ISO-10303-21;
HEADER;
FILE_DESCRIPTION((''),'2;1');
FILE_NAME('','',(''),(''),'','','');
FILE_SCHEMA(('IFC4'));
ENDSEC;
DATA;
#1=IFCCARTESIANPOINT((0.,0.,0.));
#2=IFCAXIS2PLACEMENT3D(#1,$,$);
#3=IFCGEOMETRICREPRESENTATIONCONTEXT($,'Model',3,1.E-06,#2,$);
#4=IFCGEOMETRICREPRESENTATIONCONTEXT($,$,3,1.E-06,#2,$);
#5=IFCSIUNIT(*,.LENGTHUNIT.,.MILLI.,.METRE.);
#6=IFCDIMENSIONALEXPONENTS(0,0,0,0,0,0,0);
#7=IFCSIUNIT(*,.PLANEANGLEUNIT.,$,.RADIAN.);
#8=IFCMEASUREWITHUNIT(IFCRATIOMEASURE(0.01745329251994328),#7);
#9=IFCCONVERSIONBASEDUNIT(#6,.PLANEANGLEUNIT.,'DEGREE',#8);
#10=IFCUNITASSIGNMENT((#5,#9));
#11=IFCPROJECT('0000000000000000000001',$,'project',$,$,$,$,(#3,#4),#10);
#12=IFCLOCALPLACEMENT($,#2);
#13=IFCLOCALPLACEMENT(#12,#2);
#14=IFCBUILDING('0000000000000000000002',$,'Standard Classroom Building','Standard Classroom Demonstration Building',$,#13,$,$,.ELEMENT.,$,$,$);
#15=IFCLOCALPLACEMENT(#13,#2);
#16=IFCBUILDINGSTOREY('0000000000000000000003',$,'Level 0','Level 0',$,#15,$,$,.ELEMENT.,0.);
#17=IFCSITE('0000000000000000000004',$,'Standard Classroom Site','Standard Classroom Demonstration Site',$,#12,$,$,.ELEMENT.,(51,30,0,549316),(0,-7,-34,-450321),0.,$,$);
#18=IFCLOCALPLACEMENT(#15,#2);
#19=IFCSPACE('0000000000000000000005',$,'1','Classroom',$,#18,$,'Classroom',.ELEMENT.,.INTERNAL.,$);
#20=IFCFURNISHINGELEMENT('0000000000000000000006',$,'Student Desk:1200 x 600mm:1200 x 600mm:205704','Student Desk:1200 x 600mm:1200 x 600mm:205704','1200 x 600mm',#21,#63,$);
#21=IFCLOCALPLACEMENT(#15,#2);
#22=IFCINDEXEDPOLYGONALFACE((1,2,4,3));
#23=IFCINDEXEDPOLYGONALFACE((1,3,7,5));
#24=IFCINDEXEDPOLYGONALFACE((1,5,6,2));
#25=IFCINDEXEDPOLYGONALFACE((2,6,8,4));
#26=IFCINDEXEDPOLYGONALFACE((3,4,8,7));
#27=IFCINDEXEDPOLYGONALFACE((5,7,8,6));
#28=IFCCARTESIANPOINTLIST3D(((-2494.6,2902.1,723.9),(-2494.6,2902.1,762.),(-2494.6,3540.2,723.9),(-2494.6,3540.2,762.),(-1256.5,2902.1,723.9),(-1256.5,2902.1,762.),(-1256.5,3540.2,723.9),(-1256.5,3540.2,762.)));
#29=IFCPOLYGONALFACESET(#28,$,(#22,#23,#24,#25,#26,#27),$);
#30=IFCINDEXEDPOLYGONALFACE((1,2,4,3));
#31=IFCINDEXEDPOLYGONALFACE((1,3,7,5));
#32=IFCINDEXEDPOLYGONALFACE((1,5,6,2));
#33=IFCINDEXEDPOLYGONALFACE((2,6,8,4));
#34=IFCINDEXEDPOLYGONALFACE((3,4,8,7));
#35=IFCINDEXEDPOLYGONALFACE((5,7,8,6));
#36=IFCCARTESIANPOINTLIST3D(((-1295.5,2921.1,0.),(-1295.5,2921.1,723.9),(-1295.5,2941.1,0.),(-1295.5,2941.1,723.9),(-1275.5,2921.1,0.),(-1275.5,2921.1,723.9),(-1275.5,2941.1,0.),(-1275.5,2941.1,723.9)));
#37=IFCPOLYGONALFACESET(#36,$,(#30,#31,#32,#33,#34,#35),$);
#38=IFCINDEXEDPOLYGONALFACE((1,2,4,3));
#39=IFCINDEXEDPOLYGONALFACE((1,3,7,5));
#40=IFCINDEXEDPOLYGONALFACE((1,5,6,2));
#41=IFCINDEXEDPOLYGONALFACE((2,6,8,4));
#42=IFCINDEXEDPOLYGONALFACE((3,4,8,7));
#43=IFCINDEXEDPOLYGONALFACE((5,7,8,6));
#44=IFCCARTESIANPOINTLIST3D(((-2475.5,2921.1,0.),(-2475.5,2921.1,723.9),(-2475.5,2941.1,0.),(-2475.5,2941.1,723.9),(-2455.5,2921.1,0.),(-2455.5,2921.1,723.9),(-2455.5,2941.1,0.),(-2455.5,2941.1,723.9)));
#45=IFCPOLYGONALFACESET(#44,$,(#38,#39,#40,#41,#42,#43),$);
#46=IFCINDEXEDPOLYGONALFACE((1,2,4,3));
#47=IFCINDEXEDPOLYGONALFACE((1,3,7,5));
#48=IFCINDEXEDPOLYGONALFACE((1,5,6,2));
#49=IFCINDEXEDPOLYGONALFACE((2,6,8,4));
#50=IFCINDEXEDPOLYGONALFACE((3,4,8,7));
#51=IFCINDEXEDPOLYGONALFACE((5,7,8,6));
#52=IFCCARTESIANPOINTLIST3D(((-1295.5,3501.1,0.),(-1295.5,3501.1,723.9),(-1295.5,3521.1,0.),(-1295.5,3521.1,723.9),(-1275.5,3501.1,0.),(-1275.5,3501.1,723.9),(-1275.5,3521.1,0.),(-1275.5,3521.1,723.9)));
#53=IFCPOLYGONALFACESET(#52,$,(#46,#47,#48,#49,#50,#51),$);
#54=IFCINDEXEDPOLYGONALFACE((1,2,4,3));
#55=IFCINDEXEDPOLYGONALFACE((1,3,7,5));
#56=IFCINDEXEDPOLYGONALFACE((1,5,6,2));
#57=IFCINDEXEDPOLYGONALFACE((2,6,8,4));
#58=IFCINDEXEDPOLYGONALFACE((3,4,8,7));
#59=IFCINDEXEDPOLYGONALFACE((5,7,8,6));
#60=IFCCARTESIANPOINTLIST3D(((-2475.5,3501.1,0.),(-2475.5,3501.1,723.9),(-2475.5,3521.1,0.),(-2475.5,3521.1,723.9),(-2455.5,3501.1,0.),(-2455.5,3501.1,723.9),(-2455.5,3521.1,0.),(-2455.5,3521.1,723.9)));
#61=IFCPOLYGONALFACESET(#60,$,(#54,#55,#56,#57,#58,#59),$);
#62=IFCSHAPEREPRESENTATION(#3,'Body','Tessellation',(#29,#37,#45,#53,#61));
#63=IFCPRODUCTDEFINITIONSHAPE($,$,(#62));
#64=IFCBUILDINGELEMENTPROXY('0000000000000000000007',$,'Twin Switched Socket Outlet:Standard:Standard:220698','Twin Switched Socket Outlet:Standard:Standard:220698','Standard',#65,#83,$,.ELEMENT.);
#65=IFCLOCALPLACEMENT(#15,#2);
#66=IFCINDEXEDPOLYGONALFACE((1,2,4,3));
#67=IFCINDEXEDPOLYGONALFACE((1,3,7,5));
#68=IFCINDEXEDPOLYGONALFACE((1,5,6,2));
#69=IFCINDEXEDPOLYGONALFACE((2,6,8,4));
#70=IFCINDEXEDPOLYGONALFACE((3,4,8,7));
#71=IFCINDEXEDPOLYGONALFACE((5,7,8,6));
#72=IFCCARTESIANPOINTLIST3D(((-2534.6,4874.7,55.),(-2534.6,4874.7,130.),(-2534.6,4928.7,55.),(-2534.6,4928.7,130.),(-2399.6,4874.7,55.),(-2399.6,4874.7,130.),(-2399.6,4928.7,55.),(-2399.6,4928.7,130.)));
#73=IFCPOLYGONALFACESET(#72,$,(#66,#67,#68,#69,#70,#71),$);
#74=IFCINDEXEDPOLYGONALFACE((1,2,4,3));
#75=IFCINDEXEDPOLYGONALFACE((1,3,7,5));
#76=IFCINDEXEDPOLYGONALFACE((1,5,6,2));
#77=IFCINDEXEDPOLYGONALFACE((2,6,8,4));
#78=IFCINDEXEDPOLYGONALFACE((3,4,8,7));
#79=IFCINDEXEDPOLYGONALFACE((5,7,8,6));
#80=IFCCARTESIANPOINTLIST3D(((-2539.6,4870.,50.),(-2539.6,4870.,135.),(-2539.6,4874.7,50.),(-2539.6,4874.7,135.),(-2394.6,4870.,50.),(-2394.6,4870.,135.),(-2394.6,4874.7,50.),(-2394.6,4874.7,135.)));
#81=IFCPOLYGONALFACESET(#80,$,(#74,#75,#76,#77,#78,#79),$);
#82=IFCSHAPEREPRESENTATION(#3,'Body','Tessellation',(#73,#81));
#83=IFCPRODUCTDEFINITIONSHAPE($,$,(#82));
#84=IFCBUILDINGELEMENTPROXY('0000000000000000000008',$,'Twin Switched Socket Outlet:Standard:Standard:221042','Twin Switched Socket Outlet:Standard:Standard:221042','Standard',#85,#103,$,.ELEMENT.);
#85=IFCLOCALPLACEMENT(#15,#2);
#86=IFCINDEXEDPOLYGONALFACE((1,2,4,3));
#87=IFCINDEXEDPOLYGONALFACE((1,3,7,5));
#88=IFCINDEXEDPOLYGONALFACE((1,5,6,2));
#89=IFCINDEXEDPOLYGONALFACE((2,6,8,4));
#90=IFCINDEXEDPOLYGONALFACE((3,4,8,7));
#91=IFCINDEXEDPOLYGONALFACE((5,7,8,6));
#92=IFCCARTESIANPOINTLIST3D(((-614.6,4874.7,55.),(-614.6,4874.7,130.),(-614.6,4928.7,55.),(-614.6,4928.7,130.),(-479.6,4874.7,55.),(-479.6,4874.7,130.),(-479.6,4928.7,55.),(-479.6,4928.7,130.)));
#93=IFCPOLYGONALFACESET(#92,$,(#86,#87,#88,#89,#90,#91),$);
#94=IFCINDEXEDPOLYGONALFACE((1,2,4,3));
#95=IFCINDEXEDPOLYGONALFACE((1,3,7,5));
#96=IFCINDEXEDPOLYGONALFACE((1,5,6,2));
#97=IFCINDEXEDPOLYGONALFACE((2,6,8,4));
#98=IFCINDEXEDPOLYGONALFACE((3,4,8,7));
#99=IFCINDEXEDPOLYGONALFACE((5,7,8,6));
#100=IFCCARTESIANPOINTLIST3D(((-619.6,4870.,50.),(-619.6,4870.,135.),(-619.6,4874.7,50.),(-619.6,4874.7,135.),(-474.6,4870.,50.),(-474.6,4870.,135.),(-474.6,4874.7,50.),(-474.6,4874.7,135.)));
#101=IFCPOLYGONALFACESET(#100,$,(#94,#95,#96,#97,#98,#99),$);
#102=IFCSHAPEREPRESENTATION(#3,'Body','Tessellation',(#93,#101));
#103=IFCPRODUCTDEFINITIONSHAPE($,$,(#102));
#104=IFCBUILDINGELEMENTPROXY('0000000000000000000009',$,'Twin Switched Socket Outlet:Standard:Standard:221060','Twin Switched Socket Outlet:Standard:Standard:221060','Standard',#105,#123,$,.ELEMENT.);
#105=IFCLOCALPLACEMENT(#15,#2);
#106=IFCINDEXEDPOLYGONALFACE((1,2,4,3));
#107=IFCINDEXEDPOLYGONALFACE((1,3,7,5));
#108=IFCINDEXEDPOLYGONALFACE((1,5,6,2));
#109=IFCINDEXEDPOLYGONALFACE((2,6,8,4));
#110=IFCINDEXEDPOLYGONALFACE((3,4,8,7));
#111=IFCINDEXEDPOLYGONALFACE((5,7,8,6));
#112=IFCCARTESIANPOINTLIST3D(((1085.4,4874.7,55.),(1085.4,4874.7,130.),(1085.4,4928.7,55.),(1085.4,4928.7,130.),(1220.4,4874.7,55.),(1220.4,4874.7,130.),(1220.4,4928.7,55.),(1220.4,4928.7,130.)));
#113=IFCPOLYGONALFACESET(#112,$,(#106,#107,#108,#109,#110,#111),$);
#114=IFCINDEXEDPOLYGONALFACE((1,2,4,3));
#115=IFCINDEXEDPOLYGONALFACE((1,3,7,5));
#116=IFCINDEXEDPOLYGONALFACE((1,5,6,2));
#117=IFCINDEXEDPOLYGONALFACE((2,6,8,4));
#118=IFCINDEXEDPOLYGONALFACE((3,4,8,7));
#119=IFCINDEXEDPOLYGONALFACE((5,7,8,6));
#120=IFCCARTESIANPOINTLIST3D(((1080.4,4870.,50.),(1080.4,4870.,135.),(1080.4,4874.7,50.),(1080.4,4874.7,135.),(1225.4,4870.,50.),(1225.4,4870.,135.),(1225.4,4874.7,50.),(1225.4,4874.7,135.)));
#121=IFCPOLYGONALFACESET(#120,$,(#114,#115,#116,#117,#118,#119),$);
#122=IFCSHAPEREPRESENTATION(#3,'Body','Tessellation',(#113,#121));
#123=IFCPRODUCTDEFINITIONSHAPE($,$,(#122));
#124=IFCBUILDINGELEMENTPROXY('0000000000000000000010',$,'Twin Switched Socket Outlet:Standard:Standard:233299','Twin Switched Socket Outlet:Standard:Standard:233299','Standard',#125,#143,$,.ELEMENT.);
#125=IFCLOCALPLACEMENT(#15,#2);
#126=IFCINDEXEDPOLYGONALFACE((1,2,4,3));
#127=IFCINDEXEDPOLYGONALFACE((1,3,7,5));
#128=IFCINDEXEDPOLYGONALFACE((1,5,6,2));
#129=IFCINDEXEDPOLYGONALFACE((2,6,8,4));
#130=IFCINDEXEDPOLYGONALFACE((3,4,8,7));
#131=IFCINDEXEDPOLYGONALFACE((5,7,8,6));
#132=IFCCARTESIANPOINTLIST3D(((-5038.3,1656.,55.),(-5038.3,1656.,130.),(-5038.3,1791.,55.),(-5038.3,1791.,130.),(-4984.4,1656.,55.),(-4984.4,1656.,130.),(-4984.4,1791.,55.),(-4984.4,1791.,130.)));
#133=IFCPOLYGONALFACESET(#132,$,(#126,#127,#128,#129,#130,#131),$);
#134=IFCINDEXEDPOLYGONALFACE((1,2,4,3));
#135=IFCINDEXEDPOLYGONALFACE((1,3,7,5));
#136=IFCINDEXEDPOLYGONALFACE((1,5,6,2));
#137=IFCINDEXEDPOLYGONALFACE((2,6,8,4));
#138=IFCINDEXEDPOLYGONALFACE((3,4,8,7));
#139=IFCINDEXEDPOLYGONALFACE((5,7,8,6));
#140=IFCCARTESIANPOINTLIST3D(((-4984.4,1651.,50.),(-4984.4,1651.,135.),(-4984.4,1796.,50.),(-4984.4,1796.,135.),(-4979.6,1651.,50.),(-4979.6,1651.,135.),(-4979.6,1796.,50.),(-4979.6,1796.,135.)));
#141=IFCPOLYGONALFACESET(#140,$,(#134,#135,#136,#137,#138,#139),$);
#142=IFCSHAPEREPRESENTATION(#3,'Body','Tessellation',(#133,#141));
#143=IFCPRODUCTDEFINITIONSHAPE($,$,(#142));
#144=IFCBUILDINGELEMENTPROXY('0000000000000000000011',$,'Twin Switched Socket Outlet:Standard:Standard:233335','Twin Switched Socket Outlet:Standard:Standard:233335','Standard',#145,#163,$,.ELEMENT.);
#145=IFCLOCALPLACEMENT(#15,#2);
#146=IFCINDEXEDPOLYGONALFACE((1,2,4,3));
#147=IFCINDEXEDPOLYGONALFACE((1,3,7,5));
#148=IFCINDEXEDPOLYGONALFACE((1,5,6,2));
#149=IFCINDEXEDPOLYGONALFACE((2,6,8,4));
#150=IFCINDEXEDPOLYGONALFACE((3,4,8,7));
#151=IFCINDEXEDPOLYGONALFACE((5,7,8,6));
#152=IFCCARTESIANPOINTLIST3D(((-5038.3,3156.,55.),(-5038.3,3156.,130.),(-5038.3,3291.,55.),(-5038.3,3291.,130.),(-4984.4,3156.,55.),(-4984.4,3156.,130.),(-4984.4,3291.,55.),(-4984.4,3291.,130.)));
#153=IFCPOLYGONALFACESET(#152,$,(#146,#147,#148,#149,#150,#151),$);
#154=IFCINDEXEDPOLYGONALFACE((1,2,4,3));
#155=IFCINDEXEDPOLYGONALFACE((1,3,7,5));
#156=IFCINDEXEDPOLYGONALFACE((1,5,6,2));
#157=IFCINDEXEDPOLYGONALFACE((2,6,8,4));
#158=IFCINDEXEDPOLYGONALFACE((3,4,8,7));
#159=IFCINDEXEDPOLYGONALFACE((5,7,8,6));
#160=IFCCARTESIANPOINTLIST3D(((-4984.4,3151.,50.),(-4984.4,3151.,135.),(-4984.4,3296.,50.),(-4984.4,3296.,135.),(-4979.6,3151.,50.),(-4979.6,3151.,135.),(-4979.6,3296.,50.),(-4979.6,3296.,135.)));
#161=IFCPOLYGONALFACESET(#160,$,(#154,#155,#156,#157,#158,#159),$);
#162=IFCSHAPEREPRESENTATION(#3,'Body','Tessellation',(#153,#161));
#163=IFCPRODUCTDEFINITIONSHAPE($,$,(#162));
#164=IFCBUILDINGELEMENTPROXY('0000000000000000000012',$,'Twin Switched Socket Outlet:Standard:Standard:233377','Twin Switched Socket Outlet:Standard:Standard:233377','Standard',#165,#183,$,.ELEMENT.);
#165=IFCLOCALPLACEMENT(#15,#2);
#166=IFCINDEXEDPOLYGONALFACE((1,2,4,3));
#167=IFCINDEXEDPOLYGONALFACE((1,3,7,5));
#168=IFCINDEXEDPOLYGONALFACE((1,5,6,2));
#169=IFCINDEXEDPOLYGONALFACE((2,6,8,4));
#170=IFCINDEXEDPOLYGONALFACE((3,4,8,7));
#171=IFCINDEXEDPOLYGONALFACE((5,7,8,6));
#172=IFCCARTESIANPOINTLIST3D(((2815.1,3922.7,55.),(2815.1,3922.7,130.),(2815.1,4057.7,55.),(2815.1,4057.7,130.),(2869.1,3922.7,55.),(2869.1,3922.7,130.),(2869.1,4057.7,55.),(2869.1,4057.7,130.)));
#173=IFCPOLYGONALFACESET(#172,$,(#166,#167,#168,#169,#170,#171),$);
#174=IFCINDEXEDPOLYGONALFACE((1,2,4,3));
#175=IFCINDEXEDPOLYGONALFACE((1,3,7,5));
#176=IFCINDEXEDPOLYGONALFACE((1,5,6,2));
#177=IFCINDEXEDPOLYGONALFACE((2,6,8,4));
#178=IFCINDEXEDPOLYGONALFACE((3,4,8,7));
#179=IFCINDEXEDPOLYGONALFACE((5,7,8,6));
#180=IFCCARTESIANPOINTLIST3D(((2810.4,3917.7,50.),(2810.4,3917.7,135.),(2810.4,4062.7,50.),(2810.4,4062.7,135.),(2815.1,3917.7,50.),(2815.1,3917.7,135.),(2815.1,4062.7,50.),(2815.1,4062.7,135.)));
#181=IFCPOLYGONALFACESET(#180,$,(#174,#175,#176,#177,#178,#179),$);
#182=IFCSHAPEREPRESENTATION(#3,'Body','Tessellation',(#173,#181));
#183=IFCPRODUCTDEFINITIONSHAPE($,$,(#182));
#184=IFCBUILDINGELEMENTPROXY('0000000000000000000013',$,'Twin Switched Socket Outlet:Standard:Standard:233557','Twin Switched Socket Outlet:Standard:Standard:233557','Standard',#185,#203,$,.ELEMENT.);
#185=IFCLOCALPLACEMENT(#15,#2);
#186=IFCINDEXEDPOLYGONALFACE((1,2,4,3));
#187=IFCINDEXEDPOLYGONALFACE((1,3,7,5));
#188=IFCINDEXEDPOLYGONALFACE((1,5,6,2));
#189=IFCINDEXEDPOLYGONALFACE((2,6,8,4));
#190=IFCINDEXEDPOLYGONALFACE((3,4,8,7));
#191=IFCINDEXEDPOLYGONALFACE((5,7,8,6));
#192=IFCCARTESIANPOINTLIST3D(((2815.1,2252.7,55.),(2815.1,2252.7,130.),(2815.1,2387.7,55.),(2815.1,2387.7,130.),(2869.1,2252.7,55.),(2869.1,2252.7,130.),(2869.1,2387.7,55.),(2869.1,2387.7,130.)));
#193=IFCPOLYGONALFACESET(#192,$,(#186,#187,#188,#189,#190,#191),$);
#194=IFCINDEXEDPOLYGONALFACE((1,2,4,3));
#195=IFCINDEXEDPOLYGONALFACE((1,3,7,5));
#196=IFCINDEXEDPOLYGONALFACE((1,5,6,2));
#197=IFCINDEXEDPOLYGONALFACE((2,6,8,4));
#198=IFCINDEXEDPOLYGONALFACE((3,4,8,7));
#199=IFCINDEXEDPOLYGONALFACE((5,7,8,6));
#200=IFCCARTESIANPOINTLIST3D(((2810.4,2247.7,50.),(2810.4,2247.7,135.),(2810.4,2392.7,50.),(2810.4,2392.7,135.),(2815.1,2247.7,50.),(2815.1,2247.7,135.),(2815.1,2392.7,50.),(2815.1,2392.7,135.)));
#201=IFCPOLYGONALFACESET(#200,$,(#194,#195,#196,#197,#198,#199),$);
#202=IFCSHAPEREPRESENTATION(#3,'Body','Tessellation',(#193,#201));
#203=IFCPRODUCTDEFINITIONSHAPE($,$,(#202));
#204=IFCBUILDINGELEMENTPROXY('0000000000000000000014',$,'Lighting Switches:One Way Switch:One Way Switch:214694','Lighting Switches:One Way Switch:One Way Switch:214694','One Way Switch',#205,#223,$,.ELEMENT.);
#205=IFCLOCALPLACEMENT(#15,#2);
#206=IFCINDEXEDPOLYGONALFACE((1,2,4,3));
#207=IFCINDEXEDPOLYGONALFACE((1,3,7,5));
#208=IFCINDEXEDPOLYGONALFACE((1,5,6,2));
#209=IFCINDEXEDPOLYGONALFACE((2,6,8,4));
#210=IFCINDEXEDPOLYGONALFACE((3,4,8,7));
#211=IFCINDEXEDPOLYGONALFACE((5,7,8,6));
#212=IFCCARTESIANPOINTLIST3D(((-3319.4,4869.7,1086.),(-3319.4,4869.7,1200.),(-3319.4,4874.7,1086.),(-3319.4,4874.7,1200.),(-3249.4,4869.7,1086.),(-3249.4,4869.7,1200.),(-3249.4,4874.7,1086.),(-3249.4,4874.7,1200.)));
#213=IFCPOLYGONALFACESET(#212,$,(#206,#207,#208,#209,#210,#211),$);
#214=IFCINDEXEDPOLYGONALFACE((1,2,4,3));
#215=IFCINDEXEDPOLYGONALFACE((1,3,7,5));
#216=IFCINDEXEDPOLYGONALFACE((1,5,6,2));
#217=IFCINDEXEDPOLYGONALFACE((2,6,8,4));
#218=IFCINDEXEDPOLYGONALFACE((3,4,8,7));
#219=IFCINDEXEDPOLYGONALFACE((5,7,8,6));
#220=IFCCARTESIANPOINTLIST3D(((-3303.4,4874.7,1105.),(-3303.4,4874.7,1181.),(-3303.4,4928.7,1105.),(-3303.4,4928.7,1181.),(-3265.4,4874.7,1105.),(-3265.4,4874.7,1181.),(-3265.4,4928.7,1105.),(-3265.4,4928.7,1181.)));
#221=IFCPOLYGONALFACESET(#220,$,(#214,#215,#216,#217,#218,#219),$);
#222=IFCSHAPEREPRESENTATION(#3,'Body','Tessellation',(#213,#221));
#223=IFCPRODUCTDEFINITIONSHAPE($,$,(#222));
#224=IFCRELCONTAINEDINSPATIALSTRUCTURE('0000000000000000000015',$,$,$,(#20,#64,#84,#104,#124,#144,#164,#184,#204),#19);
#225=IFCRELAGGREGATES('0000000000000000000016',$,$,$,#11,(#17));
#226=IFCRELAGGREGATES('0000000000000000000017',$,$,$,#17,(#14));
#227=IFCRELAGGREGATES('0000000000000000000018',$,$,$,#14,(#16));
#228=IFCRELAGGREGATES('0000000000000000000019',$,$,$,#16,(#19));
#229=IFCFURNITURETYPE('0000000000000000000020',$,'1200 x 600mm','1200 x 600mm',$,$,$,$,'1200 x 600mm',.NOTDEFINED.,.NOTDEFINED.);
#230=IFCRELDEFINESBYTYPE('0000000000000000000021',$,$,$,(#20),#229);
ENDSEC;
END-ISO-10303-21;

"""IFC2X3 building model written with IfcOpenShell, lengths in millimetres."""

from ifc_helpers import new_model, entity, si_unit, converted_unit, frame, origin, origin_2d_with_axis, place, context, project, spatial, rectangle, extrude, source, transform, mapped, type_object, type_shapes, element, save


model = new_model("IFC2X3")

# Units and contexts
model_context = context("Model", 3, precision=1e-06, world=origin())
context_of_model = context(None, 3, precision=1e-06, world=origin())
ifc_project = project(units=[si_unit("LENGTHUNIT", "METRE", prefix="MILLI"), converted_unit("PLANEANGLEUNIT", "DEGREE", entity("IfcRatioMeasure", 0.01745329251994328), si_unit("PLANEANGLEUNIT", "RADIAN"), dimensions=[0, 0, 0, 0, 0, 0, 0])], contexts=[model_context, context_of_model])

# Site, building, storey
site_placement = place(None, origin())
site = spatial("IfcSite", under=ifc_project, at=site_placement, Name="Standard Classroom Site", Description="Standard Classroom Demonstration Site", CompositionType="ELEMENT", RefLatitude=(51, 30, 0, 549316), RefLongitude=(0, -7, -34, -450321), RefElevation=0.0)
building_placement = place(site_placement, origin())
building = spatial("IfcBuilding", under=site, at=building_placement, Name="Standard Classroom Building", Description="Standard Classroom Demonstration Building", CompositionType="ELEMENT")
storey_placement = place(building_placement, origin())
storey = spatial("IfcBuildingStorey", under=building, at=storey_placement, Name="Level 0", Description="Level 0", CompositionType="ELEMENT", Elevation=0.0)

# Shared definitions
space_placement = place(storey_placement, origin())
space = spatial("IfcSpace", under=storey, at=space_placement, Name="1", Description="Classroom", LongName="Classroom", CompositionType="ELEMENT", InteriorOrExteriorSpace="INTERNAL")

# Furnishing element
furniture_type = type_object("IfcFurnitureType", Name="1200 x 600mm", Description="1200 x 600mm", ElementType="1200 x 600mm", AssemblyPlace="NOTDEFINED")
shared_shape_1 = source(origin(), model_context, "Body", "SweptSolid", [
    extrude(rectangle(XDim=1238.1, YDim=638.1, at=origin_2d_with_axis()), frame((600.0, 300.0, 723.9), z_axis=(0.0, 0.0, 1.0), x_axis=(-1.0, 0.0, 0.0)), (0.0, 0.0, 1.0), 38.1),
    extrude(rectangle(XDim=20.0, YDim=20.0, at=origin_2d_with_axis()), frame((1190.0, 10.0, 0.0)), (0.0, 0.0, 1.0), 723.9),
    extrude(rectangle(XDim=20.0, YDim=20.0, at=origin_2d_with_axis()), frame((10.0, 10.0, 0.0), z_axis=(0.0, 0.0, 1.0), x_axis=(0.0, 1.0, 0.0)), (0.0, 0.0, 1.0), 723.9),
    extrude(rectangle(XDim=20.0, YDim=20.0, at=origin_2d_with_axis()), frame((1190.0, 590.0, 0.0), z_axis=(0.0, 0.0, 1.0), x_axis=(0.0, -1.0, 0.0)), (0.0, 0.0, 1.0), 723.9),
    extrude(rectangle(XDim=20.0, YDim=20.0, at=origin_2d_with_axis()), frame((10.0, 590.0, 0.0), z_axis=(0.0, 0.0, 1.0), x_axis=(-1.0, 0.0, 0.0)), (0.0, 0.0, 1.0), 723.9),
])
type_shapes(furniture_type, [shared_shape_1])
for number, where, name in (
    (1, (-2475.5, 2921.1, 0.0), "Student Desk:1200 x 600mm:1200 x 600mm:205704"),
):
    element("IfcFurnishingElement", number, at=place(space_placement, frame(where)), inside=space, type_object=furniture_type, Name=name, Description="Student Desk:1200 x 600mm:1200 x 600mm:205704", ObjectType="1200 x 600mm", context=model_context, shape_type="MappedRepresentation", body=[
        mapped(shared_shape_1, transform((0.0, 0.0, 0.0), scale=1.0)),
    ])

# Building element proxies
shared_shape_2 = source(origin(), model_context, "Body", "SweptSolid", [
    extrude(rectangle(XDim=135.0, YDim=75.0, at=origin_2d_with_axis()), frame((0.0, 0.0, -54.0), z_axis=(0.0, 0.0, 1.0), x_axis=(-1.0, 0.0, 0.0)), (0.0, 0.0, 1.0), 54.0),
    extrude(rectangle(XDim=145.0, YDim=85.0, at=origin_2d_with_axis()), frame((0.0, 0.0, 0.0), z_axis=(0.0, 0.0, 1.0), x_axis=(-1.0, 0.0, 0.0)), (0.0, 0.0, 1.0), 4.8),
])
for number, where, z_axis, x_axis, name, description in (
    (2, (-2467.1, 4874.7, 92.5), (0.0, -1.0, 0.0), (1.0, 0.0, 0.0), "Twin Switched Socket Outlet:Standard:Standard:220698", "Twin Switched Socket Outlet:Standard:Standard:220698"),
    (3, (-547.1, 4874.7, 92.5), (0.0, -1.0, 0.0), (1.0, 0.0, 0.0), "Twin Switched Socket Outlet:Standard:Standard:221042", "Twin Switched Socket Outlet:Standard:Standard:221042"),
    (4, (1152.9, 4874.7, 92.5), (0.0, -1.0, 0.0), (1.0, 0.0, 0.0), "Twin Switched Socket Outlet:Standard:Standard:221060", "Twin Switched Socket Outlet:Standard:Standard:221060"),
    (5, (-4984.4, 1723.5, 92.5), (1.0, 0.0, 0.0), (0.0, 1.0, 0.0), "Twin Switched Socket Outlet:Standard:Standard:233299", "Twin Switched Socket Outlet:Standard:Standard:233299"),
    (6, (-4984.4, 3223.5, 92.5), (1.0, 0.0, 0.0), (0.0, 1.0, 0.0), "Twin Switched Socket Outlet:Standard:Standard:233335", "Twin Switched Socket Outlet:Standard:Standard:233335"),
    (7, (2815.1, 3990.2, 92.5), (-1.0, 0.0, 0.0), (0.0, -1.0, 0.0), "Twin Switched Socket Outlet:Standard:Standard:233377", "Twin Switched Socket Outlet:Standard:Standard:233377"),
    (8, (2815.1, 2320.2, 92.5), (-1.0, 0.0, 0.0), (0.0, -1.0, 0.0), "Twin Switched Socket Outlet:Standard:Standard:233557", "Twin Switched Socket Outlet:Standard:Standard:233557"),
):
    element("IfcBuildingElementProxy", number, at=place(space_placement, frame(where, z_axis=z_axis, x_axis=x_axis)), inside=space, Name=name, Description=description, ObjectType="Standard", CompositionType="ELEMENT", context=model_context, shape_type="MappedRepresentation", body=[
        mapped(shared_shape_2, transform((0.0, 0.0, 0.0), scale=1.0)),
    ])
shared_shape_3 = source(origin(), model_context, "Body", "SweptSolid", [
    extrude(rectangle(XDim=114.0, YDim=70.0, at=origin_2d_with_axis()), frame((0.0, -57.0, 0.0), z_axis=(0.0, 0.0, 1.0), x_axis=(0.0, 1.0, 0.0)), (0.0, 0.0, 1.0), 5.0),
    extrude(rectangle(XDim=76.0, YDim=38.0, at=origin_2d_with_axis()), frame((0.0, -57.0, -54.0), z_axis=(0.0, 0.0, 1.0), x_axis=(0.0, 1.0, 0.0)), (0.0, 0.0, 1.0), 54.0),
])
proxy_placement = place(space_placement, frame((-3284.4, 4874.7, 1200.0), z_axis=(0.0, -1.0, 0.0), x_axis=(1.0, 0.0, 0.0)))
element("IfcBuildingElementProxy", 9, at=proxy_placement, inside=space, Name="Lighting Switches:One Way Switch:One Way Switch:214694", Description="Lighting Switches:One Way Switch:One Way Switch:214694", ObjectType="One Way Switch", CompositionType="ELEMENT", context=model_context, shape_type="MappedRepresentation", body=[
    mapped(shared_shape_3, transform((0.0, 0.0, 0.0), scale=1.0)),
])

save(model, "model.ifc")
